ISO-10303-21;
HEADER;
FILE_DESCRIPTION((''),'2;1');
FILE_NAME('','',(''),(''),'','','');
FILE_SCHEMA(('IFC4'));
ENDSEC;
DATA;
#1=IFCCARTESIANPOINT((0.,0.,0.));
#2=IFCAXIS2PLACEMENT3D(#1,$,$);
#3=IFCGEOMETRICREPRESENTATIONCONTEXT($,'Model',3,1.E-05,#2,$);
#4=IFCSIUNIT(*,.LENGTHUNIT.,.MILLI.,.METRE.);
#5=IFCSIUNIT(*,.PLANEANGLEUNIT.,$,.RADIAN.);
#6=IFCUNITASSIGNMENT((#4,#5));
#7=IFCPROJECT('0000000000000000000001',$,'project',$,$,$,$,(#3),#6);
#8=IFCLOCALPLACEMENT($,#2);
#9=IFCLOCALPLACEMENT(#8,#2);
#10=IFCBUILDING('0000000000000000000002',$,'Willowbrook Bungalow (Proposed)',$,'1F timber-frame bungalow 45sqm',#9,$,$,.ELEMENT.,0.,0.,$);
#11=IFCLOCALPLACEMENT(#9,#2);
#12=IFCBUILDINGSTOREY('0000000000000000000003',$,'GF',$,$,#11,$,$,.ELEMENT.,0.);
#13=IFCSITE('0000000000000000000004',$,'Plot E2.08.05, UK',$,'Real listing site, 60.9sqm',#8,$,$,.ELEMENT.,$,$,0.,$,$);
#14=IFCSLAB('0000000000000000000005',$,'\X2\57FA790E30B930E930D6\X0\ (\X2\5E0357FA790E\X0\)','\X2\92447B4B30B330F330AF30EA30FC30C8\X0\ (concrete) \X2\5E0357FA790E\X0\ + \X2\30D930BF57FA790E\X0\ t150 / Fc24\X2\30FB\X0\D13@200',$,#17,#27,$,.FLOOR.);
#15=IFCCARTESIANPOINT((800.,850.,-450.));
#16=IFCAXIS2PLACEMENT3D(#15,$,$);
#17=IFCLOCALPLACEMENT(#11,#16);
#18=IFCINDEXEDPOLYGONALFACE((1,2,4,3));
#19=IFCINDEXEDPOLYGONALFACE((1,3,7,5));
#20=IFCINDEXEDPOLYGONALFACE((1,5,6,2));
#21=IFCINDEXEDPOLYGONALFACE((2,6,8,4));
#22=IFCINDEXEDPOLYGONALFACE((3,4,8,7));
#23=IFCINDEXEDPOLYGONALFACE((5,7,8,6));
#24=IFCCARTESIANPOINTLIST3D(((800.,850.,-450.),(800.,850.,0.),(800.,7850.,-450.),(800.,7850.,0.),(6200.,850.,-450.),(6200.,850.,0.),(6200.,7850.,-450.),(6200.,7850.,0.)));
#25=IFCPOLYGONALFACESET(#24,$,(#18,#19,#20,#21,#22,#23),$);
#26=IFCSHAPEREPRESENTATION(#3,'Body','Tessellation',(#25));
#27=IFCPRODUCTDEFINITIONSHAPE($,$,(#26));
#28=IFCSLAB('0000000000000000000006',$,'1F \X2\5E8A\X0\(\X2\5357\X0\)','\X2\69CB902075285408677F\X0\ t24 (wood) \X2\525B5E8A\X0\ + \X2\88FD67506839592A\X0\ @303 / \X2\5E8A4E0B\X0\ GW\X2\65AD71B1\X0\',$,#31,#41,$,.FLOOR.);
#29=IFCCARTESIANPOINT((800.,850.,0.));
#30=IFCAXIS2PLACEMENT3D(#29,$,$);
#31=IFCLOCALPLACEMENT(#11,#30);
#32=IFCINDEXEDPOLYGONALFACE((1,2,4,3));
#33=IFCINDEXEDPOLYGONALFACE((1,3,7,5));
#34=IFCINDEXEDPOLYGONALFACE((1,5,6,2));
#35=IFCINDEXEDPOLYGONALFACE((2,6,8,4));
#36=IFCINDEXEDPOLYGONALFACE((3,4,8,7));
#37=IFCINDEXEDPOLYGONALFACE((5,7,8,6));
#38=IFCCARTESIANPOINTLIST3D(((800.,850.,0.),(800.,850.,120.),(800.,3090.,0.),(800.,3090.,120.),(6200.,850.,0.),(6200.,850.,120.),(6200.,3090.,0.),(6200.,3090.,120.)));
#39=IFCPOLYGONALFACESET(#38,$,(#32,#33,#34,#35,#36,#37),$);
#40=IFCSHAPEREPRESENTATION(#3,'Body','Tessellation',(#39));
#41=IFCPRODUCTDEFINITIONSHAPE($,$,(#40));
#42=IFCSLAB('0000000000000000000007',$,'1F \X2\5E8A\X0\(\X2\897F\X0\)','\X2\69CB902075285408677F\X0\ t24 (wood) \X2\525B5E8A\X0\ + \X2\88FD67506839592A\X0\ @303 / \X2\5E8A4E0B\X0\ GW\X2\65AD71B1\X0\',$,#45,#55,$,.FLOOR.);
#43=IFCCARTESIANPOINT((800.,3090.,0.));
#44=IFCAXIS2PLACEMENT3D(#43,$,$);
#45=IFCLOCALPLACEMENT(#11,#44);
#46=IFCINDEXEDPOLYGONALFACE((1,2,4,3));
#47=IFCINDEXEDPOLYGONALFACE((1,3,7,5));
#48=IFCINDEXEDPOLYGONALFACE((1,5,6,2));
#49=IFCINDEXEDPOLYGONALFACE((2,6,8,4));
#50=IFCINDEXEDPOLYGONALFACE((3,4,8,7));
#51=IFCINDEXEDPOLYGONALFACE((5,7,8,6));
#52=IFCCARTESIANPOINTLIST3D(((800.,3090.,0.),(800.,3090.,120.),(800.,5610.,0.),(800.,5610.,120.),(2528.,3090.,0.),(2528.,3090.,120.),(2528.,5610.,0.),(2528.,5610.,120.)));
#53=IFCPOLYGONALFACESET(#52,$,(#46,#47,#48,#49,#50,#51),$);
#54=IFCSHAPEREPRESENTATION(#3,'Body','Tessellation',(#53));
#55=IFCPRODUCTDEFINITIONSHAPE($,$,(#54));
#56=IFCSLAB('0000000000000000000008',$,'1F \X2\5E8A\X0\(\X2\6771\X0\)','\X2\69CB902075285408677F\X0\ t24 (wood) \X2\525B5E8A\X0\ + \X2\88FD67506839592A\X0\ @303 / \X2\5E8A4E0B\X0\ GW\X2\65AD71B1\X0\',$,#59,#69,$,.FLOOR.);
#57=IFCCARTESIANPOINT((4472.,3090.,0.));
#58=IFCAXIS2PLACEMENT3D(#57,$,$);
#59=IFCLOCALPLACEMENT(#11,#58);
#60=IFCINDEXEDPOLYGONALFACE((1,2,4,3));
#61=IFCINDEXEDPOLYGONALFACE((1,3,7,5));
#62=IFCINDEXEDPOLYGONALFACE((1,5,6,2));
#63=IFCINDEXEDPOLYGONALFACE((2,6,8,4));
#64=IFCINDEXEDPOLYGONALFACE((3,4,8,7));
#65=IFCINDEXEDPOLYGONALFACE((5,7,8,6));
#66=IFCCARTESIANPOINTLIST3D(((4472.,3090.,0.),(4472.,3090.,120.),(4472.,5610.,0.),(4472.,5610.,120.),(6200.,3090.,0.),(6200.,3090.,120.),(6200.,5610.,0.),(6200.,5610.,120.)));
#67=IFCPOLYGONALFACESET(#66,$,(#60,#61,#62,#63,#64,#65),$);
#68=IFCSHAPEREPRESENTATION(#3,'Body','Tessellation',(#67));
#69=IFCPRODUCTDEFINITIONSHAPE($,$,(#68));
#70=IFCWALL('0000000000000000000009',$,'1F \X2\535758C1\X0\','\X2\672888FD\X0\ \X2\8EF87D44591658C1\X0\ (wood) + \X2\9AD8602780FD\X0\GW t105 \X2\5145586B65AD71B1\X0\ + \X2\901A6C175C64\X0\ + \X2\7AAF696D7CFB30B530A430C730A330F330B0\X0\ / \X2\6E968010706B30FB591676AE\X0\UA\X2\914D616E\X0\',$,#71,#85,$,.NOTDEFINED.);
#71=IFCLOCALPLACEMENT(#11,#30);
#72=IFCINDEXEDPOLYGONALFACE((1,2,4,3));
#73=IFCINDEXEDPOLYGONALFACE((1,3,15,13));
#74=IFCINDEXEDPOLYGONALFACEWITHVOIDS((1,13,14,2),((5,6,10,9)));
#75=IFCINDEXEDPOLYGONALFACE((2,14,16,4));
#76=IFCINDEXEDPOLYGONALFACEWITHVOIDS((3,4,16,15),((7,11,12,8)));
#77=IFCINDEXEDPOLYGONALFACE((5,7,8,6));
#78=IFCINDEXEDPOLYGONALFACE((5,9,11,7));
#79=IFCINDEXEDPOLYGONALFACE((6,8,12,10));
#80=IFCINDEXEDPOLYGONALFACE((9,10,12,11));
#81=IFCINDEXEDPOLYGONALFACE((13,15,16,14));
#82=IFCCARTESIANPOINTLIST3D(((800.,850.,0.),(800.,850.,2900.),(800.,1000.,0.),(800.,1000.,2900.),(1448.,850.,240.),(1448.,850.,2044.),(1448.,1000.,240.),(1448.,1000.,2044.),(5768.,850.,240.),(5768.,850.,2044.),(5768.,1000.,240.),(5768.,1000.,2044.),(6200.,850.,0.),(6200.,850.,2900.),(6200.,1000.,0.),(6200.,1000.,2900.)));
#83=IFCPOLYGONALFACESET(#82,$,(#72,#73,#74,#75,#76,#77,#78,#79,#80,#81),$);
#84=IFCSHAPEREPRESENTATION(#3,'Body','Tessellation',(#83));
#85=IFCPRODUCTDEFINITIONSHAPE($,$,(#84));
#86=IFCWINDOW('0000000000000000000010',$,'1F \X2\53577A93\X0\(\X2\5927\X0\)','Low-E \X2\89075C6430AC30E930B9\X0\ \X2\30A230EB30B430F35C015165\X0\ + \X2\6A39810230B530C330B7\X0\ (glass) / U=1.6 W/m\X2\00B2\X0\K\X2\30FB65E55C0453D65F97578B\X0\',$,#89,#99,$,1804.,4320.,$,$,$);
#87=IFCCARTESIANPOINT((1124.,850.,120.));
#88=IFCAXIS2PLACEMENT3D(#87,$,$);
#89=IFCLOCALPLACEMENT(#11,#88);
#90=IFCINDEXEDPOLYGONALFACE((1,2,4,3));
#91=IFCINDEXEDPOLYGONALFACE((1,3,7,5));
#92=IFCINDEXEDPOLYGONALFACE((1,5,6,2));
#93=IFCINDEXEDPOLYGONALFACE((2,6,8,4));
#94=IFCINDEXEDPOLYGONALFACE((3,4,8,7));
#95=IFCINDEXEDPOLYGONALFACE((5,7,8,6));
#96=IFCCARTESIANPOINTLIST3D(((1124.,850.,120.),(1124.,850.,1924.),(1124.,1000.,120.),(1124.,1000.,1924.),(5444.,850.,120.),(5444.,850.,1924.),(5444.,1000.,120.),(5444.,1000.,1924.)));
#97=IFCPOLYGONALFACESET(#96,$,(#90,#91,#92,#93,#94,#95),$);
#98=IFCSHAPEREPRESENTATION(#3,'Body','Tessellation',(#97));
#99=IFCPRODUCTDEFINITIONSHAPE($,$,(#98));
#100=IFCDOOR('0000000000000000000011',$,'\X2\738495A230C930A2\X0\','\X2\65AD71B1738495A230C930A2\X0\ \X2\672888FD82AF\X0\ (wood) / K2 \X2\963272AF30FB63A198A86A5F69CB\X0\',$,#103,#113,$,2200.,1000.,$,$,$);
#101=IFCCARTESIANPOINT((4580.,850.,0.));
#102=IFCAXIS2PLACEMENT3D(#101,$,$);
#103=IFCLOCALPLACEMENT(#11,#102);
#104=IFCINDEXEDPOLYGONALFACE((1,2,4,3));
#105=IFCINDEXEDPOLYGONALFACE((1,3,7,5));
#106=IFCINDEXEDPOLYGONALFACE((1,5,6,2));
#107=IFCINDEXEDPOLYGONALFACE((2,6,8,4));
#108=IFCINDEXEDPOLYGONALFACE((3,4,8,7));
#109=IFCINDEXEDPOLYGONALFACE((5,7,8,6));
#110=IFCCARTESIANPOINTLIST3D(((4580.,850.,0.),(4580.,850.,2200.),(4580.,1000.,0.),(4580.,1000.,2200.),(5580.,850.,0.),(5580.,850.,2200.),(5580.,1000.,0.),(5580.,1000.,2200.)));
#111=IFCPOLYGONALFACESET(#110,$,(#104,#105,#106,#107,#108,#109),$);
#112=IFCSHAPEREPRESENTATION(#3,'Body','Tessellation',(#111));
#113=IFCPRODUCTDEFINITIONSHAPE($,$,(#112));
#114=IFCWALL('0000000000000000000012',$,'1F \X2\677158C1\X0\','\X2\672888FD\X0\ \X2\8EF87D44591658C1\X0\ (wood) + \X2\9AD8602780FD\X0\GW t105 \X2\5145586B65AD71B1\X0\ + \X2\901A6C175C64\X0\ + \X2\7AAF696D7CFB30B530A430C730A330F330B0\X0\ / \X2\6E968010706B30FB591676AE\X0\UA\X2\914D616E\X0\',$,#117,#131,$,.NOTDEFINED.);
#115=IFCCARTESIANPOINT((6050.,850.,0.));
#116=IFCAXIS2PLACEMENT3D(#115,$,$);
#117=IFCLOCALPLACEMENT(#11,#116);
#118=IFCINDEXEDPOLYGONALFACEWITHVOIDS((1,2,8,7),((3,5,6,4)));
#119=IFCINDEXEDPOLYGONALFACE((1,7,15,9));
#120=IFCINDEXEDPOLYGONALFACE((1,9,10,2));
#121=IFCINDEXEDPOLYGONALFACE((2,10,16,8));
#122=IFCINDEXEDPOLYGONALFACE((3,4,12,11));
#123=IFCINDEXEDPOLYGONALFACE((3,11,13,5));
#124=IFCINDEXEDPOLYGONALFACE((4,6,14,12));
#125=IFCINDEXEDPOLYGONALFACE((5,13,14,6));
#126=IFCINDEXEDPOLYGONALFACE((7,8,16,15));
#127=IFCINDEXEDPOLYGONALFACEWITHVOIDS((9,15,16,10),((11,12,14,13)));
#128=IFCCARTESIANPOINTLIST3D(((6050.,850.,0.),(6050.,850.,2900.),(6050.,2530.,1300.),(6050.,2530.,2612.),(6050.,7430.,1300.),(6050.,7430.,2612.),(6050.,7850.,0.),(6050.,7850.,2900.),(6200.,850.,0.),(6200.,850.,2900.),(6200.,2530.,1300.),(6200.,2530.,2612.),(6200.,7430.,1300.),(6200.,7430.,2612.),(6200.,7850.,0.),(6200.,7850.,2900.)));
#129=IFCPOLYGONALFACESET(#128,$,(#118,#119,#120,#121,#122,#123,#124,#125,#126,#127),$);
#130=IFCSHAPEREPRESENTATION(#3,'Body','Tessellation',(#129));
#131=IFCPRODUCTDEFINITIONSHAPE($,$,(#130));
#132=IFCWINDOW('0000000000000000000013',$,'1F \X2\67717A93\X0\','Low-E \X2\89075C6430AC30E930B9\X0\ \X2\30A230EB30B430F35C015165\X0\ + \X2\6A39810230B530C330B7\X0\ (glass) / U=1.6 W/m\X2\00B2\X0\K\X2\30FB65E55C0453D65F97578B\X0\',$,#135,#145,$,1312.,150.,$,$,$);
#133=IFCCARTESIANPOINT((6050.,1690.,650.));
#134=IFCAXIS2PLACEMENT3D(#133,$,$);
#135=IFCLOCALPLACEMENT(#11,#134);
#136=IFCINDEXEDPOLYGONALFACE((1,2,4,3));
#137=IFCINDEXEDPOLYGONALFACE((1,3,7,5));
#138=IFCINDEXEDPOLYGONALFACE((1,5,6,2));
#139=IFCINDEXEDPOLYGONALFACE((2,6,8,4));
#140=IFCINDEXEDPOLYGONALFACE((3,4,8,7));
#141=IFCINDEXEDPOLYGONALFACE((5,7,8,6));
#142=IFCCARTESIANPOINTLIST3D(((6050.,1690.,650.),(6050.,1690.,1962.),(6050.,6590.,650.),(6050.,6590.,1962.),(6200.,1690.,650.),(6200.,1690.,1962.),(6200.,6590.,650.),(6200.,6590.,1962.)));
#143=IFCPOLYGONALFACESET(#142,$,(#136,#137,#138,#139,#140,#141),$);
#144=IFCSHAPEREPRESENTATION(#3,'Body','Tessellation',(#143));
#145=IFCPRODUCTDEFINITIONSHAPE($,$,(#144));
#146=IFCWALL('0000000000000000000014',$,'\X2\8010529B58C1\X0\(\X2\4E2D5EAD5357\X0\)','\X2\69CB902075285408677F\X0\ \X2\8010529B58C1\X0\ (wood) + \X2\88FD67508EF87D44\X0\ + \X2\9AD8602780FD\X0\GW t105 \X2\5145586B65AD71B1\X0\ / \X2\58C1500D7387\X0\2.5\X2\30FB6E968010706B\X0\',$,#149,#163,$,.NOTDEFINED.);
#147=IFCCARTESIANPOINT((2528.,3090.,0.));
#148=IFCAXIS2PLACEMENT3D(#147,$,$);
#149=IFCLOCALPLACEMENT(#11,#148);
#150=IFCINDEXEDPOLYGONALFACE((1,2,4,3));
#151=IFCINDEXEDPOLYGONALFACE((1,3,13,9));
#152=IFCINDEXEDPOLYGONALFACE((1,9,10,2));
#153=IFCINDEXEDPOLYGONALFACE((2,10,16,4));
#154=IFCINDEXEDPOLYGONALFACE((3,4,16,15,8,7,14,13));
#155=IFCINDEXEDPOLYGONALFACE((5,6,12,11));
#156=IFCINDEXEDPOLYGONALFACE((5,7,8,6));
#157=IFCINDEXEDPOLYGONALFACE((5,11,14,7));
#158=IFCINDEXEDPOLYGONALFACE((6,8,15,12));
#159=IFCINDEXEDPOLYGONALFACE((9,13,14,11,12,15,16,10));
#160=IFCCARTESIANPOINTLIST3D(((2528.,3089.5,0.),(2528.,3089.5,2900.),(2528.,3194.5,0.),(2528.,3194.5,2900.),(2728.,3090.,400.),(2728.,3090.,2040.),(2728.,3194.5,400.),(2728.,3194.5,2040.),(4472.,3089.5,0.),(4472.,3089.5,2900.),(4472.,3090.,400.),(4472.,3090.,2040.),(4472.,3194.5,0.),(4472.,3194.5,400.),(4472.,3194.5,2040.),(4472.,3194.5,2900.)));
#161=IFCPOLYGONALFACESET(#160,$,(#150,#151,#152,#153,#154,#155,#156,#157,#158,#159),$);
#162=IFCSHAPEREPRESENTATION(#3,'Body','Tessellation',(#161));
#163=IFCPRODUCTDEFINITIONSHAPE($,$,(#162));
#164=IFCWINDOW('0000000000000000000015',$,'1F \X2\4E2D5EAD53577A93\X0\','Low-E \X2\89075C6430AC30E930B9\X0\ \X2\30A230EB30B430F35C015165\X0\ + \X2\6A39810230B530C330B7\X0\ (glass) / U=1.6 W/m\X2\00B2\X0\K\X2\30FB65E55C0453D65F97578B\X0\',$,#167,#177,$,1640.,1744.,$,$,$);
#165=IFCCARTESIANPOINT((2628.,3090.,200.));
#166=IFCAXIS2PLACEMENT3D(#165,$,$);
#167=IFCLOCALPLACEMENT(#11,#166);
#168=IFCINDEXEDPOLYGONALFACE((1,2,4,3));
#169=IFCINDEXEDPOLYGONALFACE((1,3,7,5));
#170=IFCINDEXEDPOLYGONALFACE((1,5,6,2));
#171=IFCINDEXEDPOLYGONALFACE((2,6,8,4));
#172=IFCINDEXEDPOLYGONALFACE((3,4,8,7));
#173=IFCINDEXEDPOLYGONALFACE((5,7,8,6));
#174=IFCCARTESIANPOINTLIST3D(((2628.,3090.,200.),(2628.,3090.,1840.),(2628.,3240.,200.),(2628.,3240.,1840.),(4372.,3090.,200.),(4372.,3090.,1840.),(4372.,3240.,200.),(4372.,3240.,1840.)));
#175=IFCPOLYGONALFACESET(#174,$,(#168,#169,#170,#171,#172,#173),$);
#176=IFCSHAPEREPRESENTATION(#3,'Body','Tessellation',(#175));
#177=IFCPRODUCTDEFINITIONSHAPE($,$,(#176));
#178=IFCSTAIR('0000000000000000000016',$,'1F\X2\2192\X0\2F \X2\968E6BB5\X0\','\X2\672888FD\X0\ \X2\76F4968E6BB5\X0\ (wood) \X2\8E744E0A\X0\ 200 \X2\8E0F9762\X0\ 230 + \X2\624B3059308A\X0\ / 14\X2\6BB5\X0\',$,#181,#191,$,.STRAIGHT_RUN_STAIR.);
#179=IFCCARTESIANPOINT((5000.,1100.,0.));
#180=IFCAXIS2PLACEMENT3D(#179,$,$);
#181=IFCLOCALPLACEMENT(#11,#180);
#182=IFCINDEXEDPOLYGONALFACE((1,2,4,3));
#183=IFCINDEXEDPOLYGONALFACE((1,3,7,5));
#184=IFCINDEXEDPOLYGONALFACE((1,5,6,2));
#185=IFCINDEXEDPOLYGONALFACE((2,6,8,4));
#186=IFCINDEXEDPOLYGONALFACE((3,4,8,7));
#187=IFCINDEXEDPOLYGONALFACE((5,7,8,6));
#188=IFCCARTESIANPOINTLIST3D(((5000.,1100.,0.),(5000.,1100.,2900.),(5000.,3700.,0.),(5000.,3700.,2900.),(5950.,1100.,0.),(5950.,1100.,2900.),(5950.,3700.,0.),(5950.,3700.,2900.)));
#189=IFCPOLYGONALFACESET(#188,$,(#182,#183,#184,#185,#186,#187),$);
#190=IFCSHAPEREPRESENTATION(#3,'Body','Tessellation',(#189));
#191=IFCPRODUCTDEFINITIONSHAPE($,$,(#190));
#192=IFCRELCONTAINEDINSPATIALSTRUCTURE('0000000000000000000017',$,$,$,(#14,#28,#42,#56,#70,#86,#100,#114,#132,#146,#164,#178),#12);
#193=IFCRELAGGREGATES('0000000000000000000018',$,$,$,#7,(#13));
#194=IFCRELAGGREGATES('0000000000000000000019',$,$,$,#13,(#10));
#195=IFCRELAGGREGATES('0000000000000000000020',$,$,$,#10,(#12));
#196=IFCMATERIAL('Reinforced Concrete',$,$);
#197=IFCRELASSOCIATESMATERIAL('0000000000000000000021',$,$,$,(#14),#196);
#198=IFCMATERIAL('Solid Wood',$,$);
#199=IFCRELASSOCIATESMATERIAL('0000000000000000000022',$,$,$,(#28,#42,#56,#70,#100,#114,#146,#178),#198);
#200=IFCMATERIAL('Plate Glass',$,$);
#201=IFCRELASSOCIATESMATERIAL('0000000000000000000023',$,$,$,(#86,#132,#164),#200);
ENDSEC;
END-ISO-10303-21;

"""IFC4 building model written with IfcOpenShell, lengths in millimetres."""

from ifc_helpers import new_model, si_unit, frame, frame_2d, origin, place, context, project, spatial, rectangle, extrude, material, element, fill, save


model = new_model("IFC4")

# Units and contexts
model_context = context("Model", 3, precision=1e-05, world=origin())
ifc_project = project(units=[si_unit("LENGTHUNIT", "METRE", prefix="MILLI"), si_unit("PLANEANGLEUNIT", "RADIAN")], contexts=[model_context])

# Site, building, storey
site_placement = place(None, origin())
site = spatial("IfcSite", under=ifc_project, at=site_placement, Name="Plot E2.08.05, UK", ObjectType="Real listing site, 60.9sqm", CompositionType="ELEMENT", RefElevation=0.0)
building_placement = place(site_placement, origin())
building = spatial("IfcBuilding", under=site, at=building_placement, Name="Willowbrook Bungalow (Proposed)", ObjectType="1F timber-frame bungalow 45sqm", CompositionType="ELEMENT", ElevationOfRefHeight=0.0, ElevationOfTerrain=0.0)
storey_placement = place(building_placement, origin())
storey = spatial("IfcBuildingStorey", under=building, at=storey_placement, Name="GF", CompositionType="ELEMENT", Elevation=0.0)

# Slabs
ifc_material_1 = material(Name="Reinforced Concrete")
slab_1_placement = place(storey_placement, frame((800.0, 850.0, -450.0)))
element("IfcSlab", 1, at=slab_1_placement, inside=storey, material=ifc_material_1, Name="基礎スラブ (布基礎)", Description="鉄筋コンクリート (concrete) 布基礎 + ベタ基礎 t150 / Fc24・D13@200", PredefinedType="FLOOR", context=model_context, shape_type="SweptSolid", body=[
    extrude(rectangle(XDim=5400.0, YDim=7000.0, at=frame_2d((2700.0, 3500.0))), frame((800.0, 850.0, -450.0)), (0.0, 0.0, 1.0), 450.0),
])
ifc_material_2 = material(Name="Solid Wood")
slab_2_placement = place(storey_placement, frame((800.0, 850.0, 0.0)))
element("IfcSlab", 2, at=slab_2_placement, inside=storey, material=ifc_material_2, Name="1F 床(南)", Description="構造用合板 t24 (wood) 剛床 + 製材根太 @303 / 床下 GW断熱", PredefinedType="FLOOR", context=model_context, shape_type="SweptSolid", body=[
    extrude(rectangle(XDim=5400.0, YDim=2240.0, at=frame_2d((2700.0, 1120.0))), frame((800.0, 850.0, 0.0)), (0.0, 0.0, 1.0), 120.0),
])
slab_3_placement = place(storey_placement, frame((800.0, 3090.0, 0.0)))
element("IfcSlab", 3, at=slab_3_placement, inside=storey, material=ifc_material_2, Name="1F 床(西)", Description="構造用合板 t24 (wood) 剛床 + 製材根太 @303 / 床下 GW断熱", PredefinedType="FLOOR", context=model_context, shape_type="SweptSolid", body=[
    extrude(rectangle(XDim=1728.0, YDim=2520.0, at=frame_2d((864.0, 1260.0))), frame((800.0, 3090.0, 0.0)), (0.0, 0.0, 1.0), 120.0),
])
slab_4_placement = place(storey_placement, frame((4472.0, 3090.0, 0.0)))
element("IfcSlab", 4, at=slab_4_placement, inside=storey, material=ifc_material_2, Name="1F 床(東)", Description="構造用合板 t24 (wood) 剛床 + 製材根太 @303 / 床下 GW断熱", PredefinedType="FLOOR", context=model_context, shape_type="SweptSolid", body=[
    extrude(rectangle(XDim=1728.0, YDim=2520.0, at=frame_2d((864.0, 1260.0))), frame((4472.0, 3090.0, 0.0)), (0.0, 0.0, 1.0), 120.0),
])

# Wall, openings, window, door
wall_1_placement = place(storey_placement, frame((800.0, 850.0, 0.0)))
wall_1 = element("IfcWall", 5, at=wall_1_placement, inside=storey, material=ifc_material_2, Name="1F 南壁", Description="木製 軸組外壁 (wood) + 高性能GW t105 充填断熱 + 通気層 + 窯業系サイディング / 準耐火・外皮UA配慮", PredefinedType="NOTDEFINED", context=model_context, shape_type="SweptSolid", body=[
    extrude(rectangle(XDim=5400.0, YDim=150.0, at=frame_2d((2700.0, 75.0))), frame((800.0, 850.0, 0.0)), (0.0, 0.0, 1.0), 2900.0),
])
opening_1_placement = place(storey_placement, frame((1124.0, 850.0, 120.0)))
opening_1 = element("IfcOpeningElement", 6, at=opening_1_placement, cuts=wall_1, PredefinedType="NOTDEFINED", context=model_context, shape_type="SweptSolid", body=[
    extrude(rectangle(XDim=4320.0, YDim=150.0, at=frame_2d((2160.0, 75.0))), frame((1124.0, 850.0, 120.0)), (0.0, 0.0, 1.0), 1804.0),
])
opening_2_placement = place(storey_placement, frame((4580.0, 850.0, 0.0)))
opening_2 = element("IfcOpeningElement", 7, at=opening_2_placement, cuts=wall_1, PredefinedType="NOTDEFINED", context=model_context, shape_type="SweptSolid", body=[
    extrude(rectangle(XDim=1000.0, YDim=150.0, at=frame_2d((500.0, 75.0))), frame((4580.0, 850.0, 0.0)), (0.0, 0.0, 1.0), 2200.0),
])
ifc_material_3 = material(Name="Plate Glass")
window_1_placement = place(storey_placement, frame((1124.0, 850.0, 120.0)))
window_1 = element("IfcWindow", 8, at=window_1_placement, inside=storey, material=ifc_material_3, Name="1F 南窓(大)", Description="Low-E 複層ガラス アルゴン封入 + 樹脂サッシ (glass) / U=1.6 W/m²K・日射取得型", OverallHeight=1804.0, OverallWidth=4320.0, context=model_context, shape_type="SweptSolid", body=[
    extrude(rectangle(XDim=4320.0, YDim=150.0, at=frame_2d((2160.0, 75.0))), frame((1124.0, 850.0, 120.0)), (0.0, 0.0, 1.0), 1804.0),
])
fill(opening_1, window_1)
door_placement = place(storey_placement, frame((4580.0, 850.0, 0.0)))
door = element("IfcDoor", 9, at=door_placement, inside=storey, material=ifc_material_2, Name="玄関ドア", Description="断熱玄関ドア 木製芯 (wood) / K2 防犯・採風機構", OverallHeight=2200.0, OverallWidth=1000.0, context=model_context, shape_type="SweptSolid", body=[
    extrude(rectangle(XDim=1000.0, YDim=150.0, at=frame_2d((500.0, 75.0))), frame((4580.0, 850.0, 0.0)), (0.0, 0.0, 1.0), 2200.0),
])
fill(opening_2, door)

# Walls, openings, windows
wall_2_placement = place(storey_placement, frame((6050.0, 850.0, 0.0)))
wall_2 = element("IfcWall", 10, at=wall_2_placement, inside=storey, material=ifc_material_2, Name="1F 東壁", Description="木製 軸組外壁 (wood) + 高性能GW t105 充填断熱 + 通気層 + 窯業系サイディング / 準耐火・外皮UA配慮", PredefinedType="NOTDEFINED", context=model_context, shape_type="SweptSolid", body=[
    extrude(rectangle(XDim=150.0, YDim=7000.0, at=frame_2d((75.0, 3500.0))), frame((6050.0, 850.0, 0.0)), (0.0, 0.0, 1.0), 2900.0),
])
opening_3_placement = place(storey_placement, frame((6050.0, 1690.0, 650.0)))
opening_3 = element("IfcOpeningElement", 11, at=opening_3_placement, cuts=wall_2, PredefinedType="NOTDEFINED", context=model_context, shape_type="SweptSolid", body=[
    extrude(rectangle(XDim=150.0, YDim=4900.0, at=frame_2d((75.0, 2450.0))), frame((6050.0, 1690.0, 650.0)), (0.0, 0.0, 1.0), 1312.0),
])
window_2_placement = place(storey_placement, frame((6050.0, 1690.0, 650.0)))
window_2 = element("IfcWindow", 12, at=window_2_placement, inside=storey, material=ifc_material_3, Name="1F 東窓", Description="Low-E 複層ガラス アルゴン封入 + 樹脂サッシ (glass) / U=1.6 W/m²K・日射取得型", OverallHeight=1312.0, OverallWidth=150.0, context=model_context, shape_type="SweptSolid", body=[
    extrude(rectangle(XDim=150.0, YDim=4900.0, at=frame_2d((75.0, 2450.0))), frame((6050.0, 1690.0, 650.0)), (0.0, 0.0, 1.0), 1312.0),
])
fill(opening_3, window_2)
wall_3_placement = place(storey_placement, frame((2528.0, 3090.0, 0.0)))
wall_3 = element("IfcWall", 13, at=wall_3_placement, inside=storey, material=ifc_material_2, Name="耐力壁(中庭南)", Description="構造用合板 耐力壁 (wood) + 製材軸組 + 高性能GW t105 充填断熱 / 壁倍率2.5・準耐火", PredefinedType="NOTDEFINED", context=model_context, shape_type="SweptSolid", body=[
    extrude(rectangle(XDim=1944.0, YDim=105.0, at=frame_2d((972.0, 52.0))), frame((2528.0, 3090.0, 0.0)), (0.0, 0.0, 1.0), 2900.0),
])
opening_4_placement = place(storey_placement, frame((2628.0, 3090.0, 200.0)))
opening_4 = element("IfcOpeningElement", 14, at=opening_4_placement, cuts=wall_3, PredefinedType="NOTDEFINED", context=model_context, shape_type="SweptSolid", body=[
    extrude(rectangle(XDim=1744.0, YDim=150.0, at=frame_2d((872.0, 75.0))), frame((2628.0, 3090.0, 200.0)), (0.0, 0.0, 1.0), 1640.0),
])
window_3_placement = place(storey_placement, frame((2628.0, 3090.0, 200.0)))
window_3 = element("IfcWindow", 15, at=window_3_placement, inside=storey, material=ifc_material_3, Name="1F 中庭南窓", Description="Low-E 複層ガラス アルゴン封入 + 樹脂サッシ (glass) / U=1.6 W/m²K・日射取得型", OverallHeight=1640.0, OverallWidth=1744.0, context=model_context, shape_type="SweptSolid", body=[
    extrude(rectangle(XDim=1744.0, YDim=150.0, at=frame_2d((872.0, 75.0))), frame((2628.0, 3090.0, 200.0)), (0.0, 0.0, 1.0), 1640.0),
])
fill(opening_4, window_3)

# Stair
stair_placement = place(storey_placement, frame((5000.0, 1100.0, 0.0)))
element("IfcStair", 16, at=stair_placement, inside=storey, material=ifc_material_2, Name="1F→2F 階段", Description="木製 直階段 (wood) 蹴上 200 踏面 230 + 手すり / 14段", PredefinedType="STRAIGHT_RUN_STAIR", context=model_context, shape_type="SweptSolid", body=[
    extrude(rectangle(XDim=950.0, YDim=2600.0, at=frame_2d((475.0, 1300.0))), frame((5000.0, 1100.0, 0.0)), (0.0, 0.0, 1.0), 2900.0),
])

save(model, "model.ifc")
